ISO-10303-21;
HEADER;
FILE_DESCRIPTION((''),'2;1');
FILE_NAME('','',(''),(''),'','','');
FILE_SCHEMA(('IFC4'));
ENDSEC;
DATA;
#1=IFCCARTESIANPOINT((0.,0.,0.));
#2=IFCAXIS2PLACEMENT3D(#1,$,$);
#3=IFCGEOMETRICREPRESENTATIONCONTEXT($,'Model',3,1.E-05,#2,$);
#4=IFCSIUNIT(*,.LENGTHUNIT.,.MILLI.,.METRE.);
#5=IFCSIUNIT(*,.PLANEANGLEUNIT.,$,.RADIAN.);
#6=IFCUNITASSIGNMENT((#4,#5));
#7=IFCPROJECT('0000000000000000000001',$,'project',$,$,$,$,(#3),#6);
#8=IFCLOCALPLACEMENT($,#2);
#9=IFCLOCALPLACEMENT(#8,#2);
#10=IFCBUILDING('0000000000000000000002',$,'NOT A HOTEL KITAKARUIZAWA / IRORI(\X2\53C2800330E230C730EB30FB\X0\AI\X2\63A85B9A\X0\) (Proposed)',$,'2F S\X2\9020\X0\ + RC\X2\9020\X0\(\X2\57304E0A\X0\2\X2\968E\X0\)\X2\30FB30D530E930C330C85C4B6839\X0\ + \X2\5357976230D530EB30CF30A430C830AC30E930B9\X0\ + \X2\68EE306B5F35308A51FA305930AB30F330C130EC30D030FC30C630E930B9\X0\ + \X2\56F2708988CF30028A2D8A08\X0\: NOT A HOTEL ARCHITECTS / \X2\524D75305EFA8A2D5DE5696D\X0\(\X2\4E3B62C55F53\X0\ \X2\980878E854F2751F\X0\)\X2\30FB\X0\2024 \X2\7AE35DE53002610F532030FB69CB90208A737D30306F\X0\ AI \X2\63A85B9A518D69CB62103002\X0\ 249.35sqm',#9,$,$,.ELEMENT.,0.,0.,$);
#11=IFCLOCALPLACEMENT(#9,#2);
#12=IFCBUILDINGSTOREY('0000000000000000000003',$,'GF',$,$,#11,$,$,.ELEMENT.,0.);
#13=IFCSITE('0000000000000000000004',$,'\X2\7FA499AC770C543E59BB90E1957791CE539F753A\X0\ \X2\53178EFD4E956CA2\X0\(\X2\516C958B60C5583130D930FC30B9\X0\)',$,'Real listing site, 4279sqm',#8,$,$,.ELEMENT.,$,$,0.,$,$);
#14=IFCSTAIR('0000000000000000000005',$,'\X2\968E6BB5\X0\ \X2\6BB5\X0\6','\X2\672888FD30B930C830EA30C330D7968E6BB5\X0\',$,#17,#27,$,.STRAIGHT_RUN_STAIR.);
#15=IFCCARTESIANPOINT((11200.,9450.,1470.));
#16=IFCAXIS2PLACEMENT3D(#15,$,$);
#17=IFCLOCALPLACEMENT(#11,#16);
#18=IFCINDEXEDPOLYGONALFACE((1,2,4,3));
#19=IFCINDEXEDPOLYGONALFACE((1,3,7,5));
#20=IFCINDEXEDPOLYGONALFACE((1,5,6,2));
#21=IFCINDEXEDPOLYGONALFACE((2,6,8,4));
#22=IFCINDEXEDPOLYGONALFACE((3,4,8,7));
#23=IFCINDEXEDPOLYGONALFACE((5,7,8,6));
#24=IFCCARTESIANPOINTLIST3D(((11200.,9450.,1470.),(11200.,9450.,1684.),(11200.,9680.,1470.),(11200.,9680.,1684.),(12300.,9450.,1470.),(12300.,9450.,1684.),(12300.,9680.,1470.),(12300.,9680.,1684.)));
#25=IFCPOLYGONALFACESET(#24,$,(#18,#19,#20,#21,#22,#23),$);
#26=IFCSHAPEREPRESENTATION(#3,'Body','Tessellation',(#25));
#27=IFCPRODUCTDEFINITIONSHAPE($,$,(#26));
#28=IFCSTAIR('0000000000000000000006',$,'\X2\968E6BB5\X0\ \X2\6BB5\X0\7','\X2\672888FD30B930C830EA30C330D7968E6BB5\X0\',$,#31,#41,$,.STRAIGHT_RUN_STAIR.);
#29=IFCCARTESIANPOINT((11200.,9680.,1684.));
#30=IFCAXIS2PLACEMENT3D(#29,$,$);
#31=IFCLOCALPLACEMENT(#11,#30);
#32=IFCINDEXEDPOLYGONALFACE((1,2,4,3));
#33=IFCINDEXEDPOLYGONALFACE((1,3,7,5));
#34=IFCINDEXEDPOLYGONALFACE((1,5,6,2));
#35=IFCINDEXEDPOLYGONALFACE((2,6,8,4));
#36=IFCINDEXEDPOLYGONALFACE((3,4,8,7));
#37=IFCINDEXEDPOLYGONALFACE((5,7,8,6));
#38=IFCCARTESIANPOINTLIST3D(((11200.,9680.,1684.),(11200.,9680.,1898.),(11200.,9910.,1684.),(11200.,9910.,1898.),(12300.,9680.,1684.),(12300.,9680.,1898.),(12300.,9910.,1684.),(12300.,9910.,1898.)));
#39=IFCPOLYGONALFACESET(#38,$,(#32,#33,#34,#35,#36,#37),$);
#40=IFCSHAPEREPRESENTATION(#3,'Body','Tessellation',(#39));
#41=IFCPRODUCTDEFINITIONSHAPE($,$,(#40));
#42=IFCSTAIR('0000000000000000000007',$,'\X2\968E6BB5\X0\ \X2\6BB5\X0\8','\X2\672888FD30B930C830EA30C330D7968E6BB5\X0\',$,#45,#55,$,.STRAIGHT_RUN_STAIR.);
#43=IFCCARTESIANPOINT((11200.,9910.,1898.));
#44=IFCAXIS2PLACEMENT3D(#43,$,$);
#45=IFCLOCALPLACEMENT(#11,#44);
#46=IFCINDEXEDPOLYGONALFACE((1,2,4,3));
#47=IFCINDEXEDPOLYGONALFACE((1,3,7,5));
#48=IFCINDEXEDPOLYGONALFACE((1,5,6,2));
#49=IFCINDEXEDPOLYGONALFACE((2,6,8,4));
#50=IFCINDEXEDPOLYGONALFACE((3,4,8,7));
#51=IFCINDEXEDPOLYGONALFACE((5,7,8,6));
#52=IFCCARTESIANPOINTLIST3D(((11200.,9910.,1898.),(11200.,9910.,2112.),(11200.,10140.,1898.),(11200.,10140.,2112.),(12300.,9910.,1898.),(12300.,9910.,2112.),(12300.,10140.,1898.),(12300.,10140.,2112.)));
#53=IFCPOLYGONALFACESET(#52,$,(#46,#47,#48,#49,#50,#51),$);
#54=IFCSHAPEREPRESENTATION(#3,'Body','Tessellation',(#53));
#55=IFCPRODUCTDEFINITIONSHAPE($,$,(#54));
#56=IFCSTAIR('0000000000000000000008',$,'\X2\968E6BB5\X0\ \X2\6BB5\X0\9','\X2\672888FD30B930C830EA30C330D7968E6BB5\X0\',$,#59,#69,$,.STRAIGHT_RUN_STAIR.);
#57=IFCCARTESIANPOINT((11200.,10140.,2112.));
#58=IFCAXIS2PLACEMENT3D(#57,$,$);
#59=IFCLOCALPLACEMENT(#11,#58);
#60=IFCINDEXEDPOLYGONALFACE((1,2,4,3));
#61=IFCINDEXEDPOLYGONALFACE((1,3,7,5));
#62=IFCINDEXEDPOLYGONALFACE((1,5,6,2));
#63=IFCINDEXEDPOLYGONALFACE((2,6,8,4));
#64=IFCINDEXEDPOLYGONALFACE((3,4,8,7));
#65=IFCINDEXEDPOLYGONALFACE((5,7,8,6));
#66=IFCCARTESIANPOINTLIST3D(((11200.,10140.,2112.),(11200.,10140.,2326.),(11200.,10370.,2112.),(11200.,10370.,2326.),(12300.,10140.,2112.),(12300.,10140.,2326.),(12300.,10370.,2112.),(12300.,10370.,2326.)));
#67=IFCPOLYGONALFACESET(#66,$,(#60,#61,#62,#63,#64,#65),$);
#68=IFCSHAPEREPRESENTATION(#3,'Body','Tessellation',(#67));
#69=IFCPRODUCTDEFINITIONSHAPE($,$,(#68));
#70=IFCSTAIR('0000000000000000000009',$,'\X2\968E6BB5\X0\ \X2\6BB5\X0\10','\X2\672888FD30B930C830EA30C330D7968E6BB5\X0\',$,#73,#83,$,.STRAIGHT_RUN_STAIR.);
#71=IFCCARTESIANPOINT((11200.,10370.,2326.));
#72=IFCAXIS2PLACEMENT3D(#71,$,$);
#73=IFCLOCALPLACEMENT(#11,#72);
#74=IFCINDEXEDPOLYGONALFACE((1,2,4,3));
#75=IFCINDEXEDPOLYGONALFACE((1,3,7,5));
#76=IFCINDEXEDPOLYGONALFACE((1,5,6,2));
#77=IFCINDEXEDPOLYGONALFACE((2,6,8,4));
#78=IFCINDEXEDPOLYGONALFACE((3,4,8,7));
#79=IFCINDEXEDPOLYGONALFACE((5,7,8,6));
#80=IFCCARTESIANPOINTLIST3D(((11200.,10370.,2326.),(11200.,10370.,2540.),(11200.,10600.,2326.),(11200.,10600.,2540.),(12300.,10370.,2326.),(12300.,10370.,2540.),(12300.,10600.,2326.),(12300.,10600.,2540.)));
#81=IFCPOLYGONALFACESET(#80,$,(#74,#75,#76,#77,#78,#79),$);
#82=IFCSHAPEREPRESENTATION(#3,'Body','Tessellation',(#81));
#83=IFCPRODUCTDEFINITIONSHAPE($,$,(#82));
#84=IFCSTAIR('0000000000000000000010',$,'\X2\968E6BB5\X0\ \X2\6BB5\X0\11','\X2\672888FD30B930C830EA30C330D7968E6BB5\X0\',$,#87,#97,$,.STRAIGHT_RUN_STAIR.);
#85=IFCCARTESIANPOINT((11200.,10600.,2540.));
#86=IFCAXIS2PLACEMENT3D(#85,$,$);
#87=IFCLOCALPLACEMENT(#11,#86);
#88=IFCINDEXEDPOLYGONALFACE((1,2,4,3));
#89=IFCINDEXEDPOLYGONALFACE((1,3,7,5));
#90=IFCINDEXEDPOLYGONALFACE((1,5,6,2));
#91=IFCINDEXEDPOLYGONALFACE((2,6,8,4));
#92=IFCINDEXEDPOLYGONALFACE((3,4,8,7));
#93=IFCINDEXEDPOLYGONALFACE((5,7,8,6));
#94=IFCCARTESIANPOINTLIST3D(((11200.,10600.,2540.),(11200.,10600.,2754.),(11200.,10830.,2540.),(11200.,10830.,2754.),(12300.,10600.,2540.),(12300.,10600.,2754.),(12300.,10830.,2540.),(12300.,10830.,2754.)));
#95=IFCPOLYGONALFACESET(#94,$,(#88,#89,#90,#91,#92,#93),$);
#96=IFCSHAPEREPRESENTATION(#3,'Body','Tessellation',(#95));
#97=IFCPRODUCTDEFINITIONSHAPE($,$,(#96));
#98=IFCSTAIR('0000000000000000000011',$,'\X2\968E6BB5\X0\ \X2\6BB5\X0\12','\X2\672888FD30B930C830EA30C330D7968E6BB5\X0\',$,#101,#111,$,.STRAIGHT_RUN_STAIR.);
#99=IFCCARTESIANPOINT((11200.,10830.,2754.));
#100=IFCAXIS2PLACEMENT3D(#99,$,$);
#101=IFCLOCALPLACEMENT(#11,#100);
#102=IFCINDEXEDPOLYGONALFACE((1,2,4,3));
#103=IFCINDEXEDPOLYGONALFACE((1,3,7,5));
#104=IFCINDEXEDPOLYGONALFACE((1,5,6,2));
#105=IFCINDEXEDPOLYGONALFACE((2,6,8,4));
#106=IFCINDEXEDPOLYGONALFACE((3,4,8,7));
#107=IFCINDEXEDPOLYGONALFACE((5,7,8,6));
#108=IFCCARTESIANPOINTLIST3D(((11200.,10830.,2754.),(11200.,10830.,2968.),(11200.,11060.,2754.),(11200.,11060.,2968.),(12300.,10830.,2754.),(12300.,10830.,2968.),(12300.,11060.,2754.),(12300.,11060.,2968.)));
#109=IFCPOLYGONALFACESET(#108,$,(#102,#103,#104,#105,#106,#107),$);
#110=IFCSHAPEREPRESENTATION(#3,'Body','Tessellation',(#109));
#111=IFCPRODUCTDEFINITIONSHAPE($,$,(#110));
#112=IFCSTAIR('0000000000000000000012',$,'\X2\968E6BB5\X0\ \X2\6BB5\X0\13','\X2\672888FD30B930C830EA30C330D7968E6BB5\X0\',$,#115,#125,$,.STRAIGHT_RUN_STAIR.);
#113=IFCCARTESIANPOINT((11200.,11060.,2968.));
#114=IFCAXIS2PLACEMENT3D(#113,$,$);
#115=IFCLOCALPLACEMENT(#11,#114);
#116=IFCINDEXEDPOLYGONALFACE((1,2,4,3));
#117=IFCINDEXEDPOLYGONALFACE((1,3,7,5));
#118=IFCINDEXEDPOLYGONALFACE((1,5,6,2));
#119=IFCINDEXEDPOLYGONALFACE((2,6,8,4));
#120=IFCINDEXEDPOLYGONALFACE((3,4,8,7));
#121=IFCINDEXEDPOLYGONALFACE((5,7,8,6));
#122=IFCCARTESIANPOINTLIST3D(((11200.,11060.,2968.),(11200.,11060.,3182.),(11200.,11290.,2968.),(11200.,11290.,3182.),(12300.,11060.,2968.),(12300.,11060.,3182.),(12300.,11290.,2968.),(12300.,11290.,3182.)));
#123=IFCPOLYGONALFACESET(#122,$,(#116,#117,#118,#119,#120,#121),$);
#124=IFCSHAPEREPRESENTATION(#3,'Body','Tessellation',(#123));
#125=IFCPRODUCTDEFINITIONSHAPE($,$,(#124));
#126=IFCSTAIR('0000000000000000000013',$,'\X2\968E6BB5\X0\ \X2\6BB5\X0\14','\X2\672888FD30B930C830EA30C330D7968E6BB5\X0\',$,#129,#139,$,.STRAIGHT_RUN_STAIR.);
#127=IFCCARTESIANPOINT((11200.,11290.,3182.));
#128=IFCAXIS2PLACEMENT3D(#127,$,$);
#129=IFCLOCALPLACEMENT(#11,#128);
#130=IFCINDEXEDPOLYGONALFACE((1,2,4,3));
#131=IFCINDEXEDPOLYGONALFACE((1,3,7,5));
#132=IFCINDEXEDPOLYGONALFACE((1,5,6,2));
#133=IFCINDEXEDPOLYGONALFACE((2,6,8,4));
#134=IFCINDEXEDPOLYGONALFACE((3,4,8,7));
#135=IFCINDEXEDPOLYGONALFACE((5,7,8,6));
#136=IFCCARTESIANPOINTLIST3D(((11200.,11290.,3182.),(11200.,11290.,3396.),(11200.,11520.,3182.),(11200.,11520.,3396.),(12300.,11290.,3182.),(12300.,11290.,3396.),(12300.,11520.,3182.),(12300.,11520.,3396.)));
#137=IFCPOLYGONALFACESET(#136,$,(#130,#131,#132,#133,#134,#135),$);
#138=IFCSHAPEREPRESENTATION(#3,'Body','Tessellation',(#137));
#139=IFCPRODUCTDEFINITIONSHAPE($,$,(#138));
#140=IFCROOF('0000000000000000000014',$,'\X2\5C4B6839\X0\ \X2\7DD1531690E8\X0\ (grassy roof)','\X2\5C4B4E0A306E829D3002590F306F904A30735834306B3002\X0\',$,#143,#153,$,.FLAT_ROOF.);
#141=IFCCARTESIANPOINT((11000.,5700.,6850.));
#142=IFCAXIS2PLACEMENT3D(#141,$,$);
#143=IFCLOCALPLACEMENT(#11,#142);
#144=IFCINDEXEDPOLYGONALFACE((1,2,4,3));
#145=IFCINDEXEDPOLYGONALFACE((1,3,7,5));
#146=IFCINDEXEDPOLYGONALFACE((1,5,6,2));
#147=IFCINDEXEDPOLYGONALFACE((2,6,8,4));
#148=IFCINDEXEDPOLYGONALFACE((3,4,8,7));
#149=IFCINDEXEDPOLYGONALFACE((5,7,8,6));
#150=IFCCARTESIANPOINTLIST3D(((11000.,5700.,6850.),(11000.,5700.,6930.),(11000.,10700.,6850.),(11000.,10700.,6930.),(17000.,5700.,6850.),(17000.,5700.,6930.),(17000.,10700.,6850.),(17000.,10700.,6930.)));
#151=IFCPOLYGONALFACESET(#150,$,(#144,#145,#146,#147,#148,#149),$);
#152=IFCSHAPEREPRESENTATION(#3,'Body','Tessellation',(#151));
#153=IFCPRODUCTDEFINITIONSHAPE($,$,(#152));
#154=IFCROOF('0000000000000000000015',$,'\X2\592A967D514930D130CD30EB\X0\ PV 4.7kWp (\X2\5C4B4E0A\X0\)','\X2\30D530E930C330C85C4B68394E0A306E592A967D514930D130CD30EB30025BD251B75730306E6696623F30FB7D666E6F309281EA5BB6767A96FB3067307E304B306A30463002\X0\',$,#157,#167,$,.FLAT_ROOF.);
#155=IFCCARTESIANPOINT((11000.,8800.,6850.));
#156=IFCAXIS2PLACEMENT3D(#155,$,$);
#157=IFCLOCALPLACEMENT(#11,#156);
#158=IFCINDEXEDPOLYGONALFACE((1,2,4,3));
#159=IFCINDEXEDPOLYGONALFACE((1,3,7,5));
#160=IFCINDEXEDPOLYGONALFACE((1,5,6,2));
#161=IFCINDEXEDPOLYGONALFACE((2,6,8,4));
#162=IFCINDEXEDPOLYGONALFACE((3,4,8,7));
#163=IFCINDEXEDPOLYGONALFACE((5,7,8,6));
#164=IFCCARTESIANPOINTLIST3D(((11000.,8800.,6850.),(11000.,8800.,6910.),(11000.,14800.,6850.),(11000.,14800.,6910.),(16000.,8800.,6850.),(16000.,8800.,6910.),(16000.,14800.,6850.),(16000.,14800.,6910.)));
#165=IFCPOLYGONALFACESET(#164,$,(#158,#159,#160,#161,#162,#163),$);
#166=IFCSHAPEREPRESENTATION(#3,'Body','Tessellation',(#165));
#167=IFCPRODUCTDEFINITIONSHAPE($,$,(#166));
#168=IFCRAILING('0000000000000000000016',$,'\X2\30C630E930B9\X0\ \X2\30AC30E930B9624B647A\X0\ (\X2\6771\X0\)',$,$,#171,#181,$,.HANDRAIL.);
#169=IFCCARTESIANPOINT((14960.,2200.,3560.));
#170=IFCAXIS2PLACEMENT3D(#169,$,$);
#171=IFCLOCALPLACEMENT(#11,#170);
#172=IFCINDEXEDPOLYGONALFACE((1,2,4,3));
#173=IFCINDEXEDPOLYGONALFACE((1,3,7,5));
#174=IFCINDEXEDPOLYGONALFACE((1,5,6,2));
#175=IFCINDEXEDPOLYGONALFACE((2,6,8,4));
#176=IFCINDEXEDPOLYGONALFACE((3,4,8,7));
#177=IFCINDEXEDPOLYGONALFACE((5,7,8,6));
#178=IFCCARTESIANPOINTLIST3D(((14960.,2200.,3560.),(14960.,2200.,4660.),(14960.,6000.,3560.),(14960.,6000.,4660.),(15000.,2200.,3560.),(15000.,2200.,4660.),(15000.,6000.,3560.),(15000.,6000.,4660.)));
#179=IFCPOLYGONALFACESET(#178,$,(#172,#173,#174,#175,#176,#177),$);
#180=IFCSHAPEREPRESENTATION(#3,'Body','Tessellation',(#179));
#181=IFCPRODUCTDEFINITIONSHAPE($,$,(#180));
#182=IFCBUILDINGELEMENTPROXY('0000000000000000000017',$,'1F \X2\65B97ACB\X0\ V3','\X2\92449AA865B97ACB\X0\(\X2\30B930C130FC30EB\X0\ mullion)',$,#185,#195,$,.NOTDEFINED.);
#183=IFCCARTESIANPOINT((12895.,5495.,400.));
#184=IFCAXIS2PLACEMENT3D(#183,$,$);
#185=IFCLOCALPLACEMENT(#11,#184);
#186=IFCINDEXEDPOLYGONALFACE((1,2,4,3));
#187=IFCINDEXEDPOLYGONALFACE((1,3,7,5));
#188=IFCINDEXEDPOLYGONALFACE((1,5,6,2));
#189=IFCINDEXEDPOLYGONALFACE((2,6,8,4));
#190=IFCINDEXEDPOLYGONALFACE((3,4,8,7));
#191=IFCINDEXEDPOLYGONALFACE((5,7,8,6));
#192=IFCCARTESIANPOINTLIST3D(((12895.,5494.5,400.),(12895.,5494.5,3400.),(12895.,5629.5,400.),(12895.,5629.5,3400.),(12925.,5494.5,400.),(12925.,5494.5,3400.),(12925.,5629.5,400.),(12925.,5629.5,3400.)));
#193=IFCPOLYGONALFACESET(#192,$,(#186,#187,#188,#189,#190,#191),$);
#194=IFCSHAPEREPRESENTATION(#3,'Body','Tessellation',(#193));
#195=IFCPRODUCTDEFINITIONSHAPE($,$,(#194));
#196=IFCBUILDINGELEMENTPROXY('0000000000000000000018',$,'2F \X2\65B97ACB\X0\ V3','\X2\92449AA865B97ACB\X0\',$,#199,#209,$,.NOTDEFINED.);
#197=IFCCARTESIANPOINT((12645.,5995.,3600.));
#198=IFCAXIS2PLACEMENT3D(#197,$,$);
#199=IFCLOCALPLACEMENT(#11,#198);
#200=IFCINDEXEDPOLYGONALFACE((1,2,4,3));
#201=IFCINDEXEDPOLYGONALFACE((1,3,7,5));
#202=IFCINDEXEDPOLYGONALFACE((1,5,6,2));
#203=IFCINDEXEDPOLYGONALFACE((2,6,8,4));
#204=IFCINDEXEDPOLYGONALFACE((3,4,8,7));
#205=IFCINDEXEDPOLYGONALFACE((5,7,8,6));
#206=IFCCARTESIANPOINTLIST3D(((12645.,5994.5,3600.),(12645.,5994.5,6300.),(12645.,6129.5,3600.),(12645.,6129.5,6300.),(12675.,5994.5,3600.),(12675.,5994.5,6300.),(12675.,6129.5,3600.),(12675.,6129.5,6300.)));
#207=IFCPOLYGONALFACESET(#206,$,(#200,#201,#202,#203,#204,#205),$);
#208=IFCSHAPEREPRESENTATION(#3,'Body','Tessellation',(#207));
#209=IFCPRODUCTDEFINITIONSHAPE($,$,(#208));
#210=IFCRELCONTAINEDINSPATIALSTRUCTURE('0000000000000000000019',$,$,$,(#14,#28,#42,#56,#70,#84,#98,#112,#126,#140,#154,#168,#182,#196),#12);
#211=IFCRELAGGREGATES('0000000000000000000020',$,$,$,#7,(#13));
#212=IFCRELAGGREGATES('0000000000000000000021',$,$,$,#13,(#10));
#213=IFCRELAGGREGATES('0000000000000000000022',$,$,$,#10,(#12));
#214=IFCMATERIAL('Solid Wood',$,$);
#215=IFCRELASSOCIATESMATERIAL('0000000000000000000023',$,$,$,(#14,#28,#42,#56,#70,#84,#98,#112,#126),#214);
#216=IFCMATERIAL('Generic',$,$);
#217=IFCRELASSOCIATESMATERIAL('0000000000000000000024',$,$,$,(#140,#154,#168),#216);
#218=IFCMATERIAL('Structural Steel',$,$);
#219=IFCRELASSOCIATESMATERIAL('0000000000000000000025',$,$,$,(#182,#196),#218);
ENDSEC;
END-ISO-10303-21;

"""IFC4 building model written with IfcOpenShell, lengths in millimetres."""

from ifc_helpers import new_model, si_unit, frame, frame_2d, origin, place, context, project, spatial, rectangle, extrude, material, element, save


model = new_model("IFC4")

# Units and contexts
model_context = context("Model", 3, precision=1e-05, world=origin())
ifc_project = project(units=[si_unit("LENGTHUNIT", "METRE", prefix="MILLI"), si_unit("PLANEANGLEUNIT", "RADIAN")], contexts=[model_context])

# Site, building, storey
site_placement = place(None, origin())
site = spatial("IfcSite", under=ifc_project, at=site_placement, Name="群馬県吾妻郡長野原町 北軽井沢(公開情報ベース)", ObjectType="Real listing site, 4279sqm", CompositionType="ELEMENT", RefElevation=0.0)
building_placement = place(site_placement, origin())
building = spatial("IfcBuilding", under=site, at=building_placement, Name="NOT A HOTEL KITAKARUIZAWA / IRORI(参考モデル・AI推定) (Proposed)", ObjectType="2F S造 + RC造(地上2階)・フラット屋根 + 南面フルハイトガラス + 森に張り出すカンチレバーテラス + 囲炉裏。設計: NOT A HOTEL ARCHITECTS / 前田建設工業(主担当 須磨哲生)・2024 竣工。意匠・構造詳細は AI 推定再構成。 249.35sqm", CompositionType="ELEMENT", ElevationOfRefHeight=0.0, ElevationOfTerrain=0.0)
storey_placement = place(building_placement, origin())
storey = spatial("IfcBuildingStorey", under=building, at=storey_placement, Name="GF", CompositionType="ELEMENT", Elevation=0.0)

# Shared definitions
ifc_material_1 = material(Name="Structural Steel")

# Shared definitions
ifc_material_2 = material(Name="Generic")

# Stairs
ifc_material_3 = material(Name="Solid Wood")
stair_1_placement = place(storey_placement, frame((11200.0, 9450.0, 1470.0)))
element("IfcStair", 1, at=stair_1_placement, inside=storey, material=ifc_material_3, Name="階段 段6", Description="木製ストリップ階段", PredefinedType="STRAIGHT_RUN_STAIR", context=model_context, shape_type="SweptSolid", body=[
    extrude(rectangle(XDim=1100.0, YDim=230.0, at=frame_2d((550.0, 115.0))), frame((11200.0, 9450.0, 1470.0)), (0.0, 0.0, 1.0), 214.0),
])
stair_2_placement = place(storey_placement, frame((11200.0, 9680.0, 1684.0)))
element("IfcStair", 2, at=stair_2_placement, inside=storey, material=ifc_material_3, Name="階段 段7", Description="木製ストリップ階段", PredefinedType="STRAIGHT_RUN_STAIR", context=model_context, shape_type="SweptSolid", body=[
    extrude(rectangle(XDim=1100.0, YDim=230.0, at=frame_2d((550.0, 115.0))), frame((11200.0, 9680.0, 1684.0)), (0.0, 0.0, 1.0), 214.0),
])
stair_3_placement = place(storey_placement, frame((11200.0, 9910.0, 1898.0)))
element("IfcStair", 3, at=stair_3_placement, inside=storey, material=ifc_material_3, Name="階段 段8", Description="木製ストリップ階段", PredefinedType="STRAIGHT_RUN_STAIR", context=model_context, shape_type="SweptSolid", body=[
    extrude(rectangle(XDim=1100.0, YDim=230.0, at=frame_2d((550.0, 115.0))), frame((11200.0, 9910.0, 1898.0)), (0.0, 0.0, 1.0), 214.0),
])
stair_4_placement = place(storey_placement, frame((11200.0, 10140.0, 2112.0)))
element("IfcStair", 4, at=stair_4_placement, inside=storey, material=ifc_material_3, Name="階段 段9", Description="木製ストリップ階段", PredefinedType="STRAIGHT_RUN_STAIR", context=model_context, shape_type="SweptSolid", body=[
    extrude(rectangle(XDim=1100.0, YDim=230.0, at=frame_2d((550.0, 115.0))), frame((11200.0, 10140.0, 2112.0)), (0.0, 0.0, 1.0), 214.0),
])
stair_5_placement = place(storey_placement, frame((11200.0, 10370.0, 2326.0)))
element("IfcStair", 5, at=stair_5_placement, inside=storey, material=ifc_material_3, Name="階段 段10", Description="木製ストリップ階段", PredefinedType="STRAIGHT_RUN_STAIR", context=model_context, shape_type="SweptSolid", body=[
    extrude(rectangle(XDim=1100.0, YDim=230.0, at=frame_2d((550.0, 115.0))), frame((11200.0, 10370.0, 2326.0)), (0.0, 0.0, 1.0), 214.0),
])
stair_6_placement = place(storey_placement, frame((11200.0, 10600.0, 2540.0)))
element("IfcStair", 6, at=stair_6_placement, inside=storey, material=ifc_material_3, Name="階段 段11", Description="木製ストリップ階段", PredefinedType="STRAIGHT_RUN_STAIR", context=model_context, shape_type="SweptSolid", body=[
    extrude(rectangle(XDim=1100.0, YDim=230.0, at=frame_2d((550.0, 115.0))), frame((11200.0, 10600.0, 2540.0)), (0.0, 0.0, 1.0), 214.0),
])
stair_7_placement = place(storey_placement, frame((11200.0, 10830.0, 2754.0)))
element("IfcStair", 7, at=stair_7_placement, inside=storey, material=ifc_material_3, Name="階段 段12", Description="木製ストリップ階段", PredefinedType="STRAIGHT_RUN_STAIR", context=model_context, shape_type="SweptSolid", body=[
    extrude(rectangle(XDim=1100.0, YDim=230.0, at=frame_2d((550.0, 115.0))), frame((11200.0, 10830.0, 2754.0)), (0.0, 0.0, 1.0), 214.0),
])
stair_8_placement = place(storey_placement, frame((11200.0, 11060.0, 2968.0)))
element("IfcStair", 8, at=stair_8_placement, inside=storey, material=ifc_material_3, Name="階段 段13", Description="木製ストリップ階段", PredefinedType="STRAIGHT_RUN_STAIR", context=model_context, shape_type="SweptSolid", body=[
    extrude(rectangle(XDim=1100.0, YDim=230.0, at=frame_2d((550.0, 115.0))), frame((11200.0, 11060.0, 2968.0)), (0.0, 0.0, 1.0), 214.0),
])
stair_9_placement = place(storey_placement, frame((11200.0, 11290.0, 3182.0)))
element("IfcStair", 9, at=stair_9_placement, inside=storey, material=ifc_material_3, Name="階段 段14", Description="木製ストリップ階段", PredefinedType="STRAIGHT_RUN_STAIR", context=model_context, shape_type="SweptSolid", body=[
    extrude(rectangle(XDim=1100.0, YDim=230.0, at=frame_2d((550.0, 115.0))), frame((11200.0, 11290.0, 3182.0)), (0.0, 0.0, 1.0), 214.0),
])

# Roofs
roof_1_placement = place(storey_placement, frame((11000.0, 5700.0, 6850.0)))
element("IfcRoof", 10, at=roof_1_placement, inside=storey, material=ifc_material_2, Name="屋根 緑化部 (grassy roof)", Description="屋上の芝。夏は遊び場に。", PredefinedType="FLAT_ROOF", context=model_context, shape_type="SweptSolid", body=[
    extrude(rectangle(XDim=6000.0, YDim=5000.0, at=frame_2d((3000.0, 2500.0))), frame((11000.0, 5700.0, 6850.0)), (0.0, 0.0, 1.0), 80.0),
])
roof_2_placement = place(storey_placement, frame((11000.0, 8800.0, 6850.0)))
element("IfcRoof", 11, at=roof_2_placement, inside=storey, material=ifc_material_2, Name="太陽光パネル PV 4.7kWp (屋上)", Description="フラット屋根上の太陽光パネル。寒冷地の暖房・給湯を自家発電でまかなう。", PredefinedType="FLAT_ROOF", context=model_context, shape_type="SweptSolid", body=[
    extrude(rectangle(XDim=5000.0, YDim=6000.0, at=frame_2d((2500.0, 3000.0))), frame((11000.0, 8800.0, 6850.0)), (0.0, 0.0, 1.0), 60.0),
])

# Railing
railing_placement = place(storey_placement, frame((14960.0, 2200.0, 3560.0)))
element("IfcRailing", 12, at=railing_placement, inside=storey, material=ifc_material_2, Name="テラス ガラス手摺 (東)", PredefinedType="HANDRAIL", context=model_context, shape_type="SweptSolid", body=[
    extrude(rectangle(XDim=40.0, YDim=3800.0, at=frame_2d((20.0, 1900.0))), frame((14960.0, 2200.0, 3560.0)), (0.0, 0.0, 1.0), 1100.0),
])

# Building element proxies
proxy_1_placement = place(storey_placement, frame((12895.0, 5495.0, 400.0)))
element("IfcBuildingElementProxy", 13, at=proxy_1_placement, inside=storey, material=ifc_material_1, Name="1F 方立 V3", Description="鉄骨方立(スチール mullion)", PredefinedType="NOTDEFINED", context=model_context, shape_type="SweptSolid", body=[
    extrude(rectangle(XDim=30.0, YDim=135.0, at=frame_2d((15.0, 67.0))), frame((12895.0, 5495.0, 400.0)), (0.0, 0.0, 1.0), 3000.0),
])
proxy_2_placement = place(storey_placement, frame((12645.0, 5995.0, 3600.0)))
element("IfcBuildingElementProxy", 14, at=proxy_2_placement, inside=storey, material=ifc_material_1, Name="2F 方立 V3", Description="鉄骨方立", PredefinedType="NOTDEFINED", context=model_context, shape_type="SweptSolid", body=[
    extrude(rectangle(XDim=30.0, YDim=135.0, at=frame_2d((15.0, 67.0))), frame((12645.0, 5995.0, 3600.0)), (0.0, 0.0, 1.0), 2700.0),
])

save(model, "model.ifc")
